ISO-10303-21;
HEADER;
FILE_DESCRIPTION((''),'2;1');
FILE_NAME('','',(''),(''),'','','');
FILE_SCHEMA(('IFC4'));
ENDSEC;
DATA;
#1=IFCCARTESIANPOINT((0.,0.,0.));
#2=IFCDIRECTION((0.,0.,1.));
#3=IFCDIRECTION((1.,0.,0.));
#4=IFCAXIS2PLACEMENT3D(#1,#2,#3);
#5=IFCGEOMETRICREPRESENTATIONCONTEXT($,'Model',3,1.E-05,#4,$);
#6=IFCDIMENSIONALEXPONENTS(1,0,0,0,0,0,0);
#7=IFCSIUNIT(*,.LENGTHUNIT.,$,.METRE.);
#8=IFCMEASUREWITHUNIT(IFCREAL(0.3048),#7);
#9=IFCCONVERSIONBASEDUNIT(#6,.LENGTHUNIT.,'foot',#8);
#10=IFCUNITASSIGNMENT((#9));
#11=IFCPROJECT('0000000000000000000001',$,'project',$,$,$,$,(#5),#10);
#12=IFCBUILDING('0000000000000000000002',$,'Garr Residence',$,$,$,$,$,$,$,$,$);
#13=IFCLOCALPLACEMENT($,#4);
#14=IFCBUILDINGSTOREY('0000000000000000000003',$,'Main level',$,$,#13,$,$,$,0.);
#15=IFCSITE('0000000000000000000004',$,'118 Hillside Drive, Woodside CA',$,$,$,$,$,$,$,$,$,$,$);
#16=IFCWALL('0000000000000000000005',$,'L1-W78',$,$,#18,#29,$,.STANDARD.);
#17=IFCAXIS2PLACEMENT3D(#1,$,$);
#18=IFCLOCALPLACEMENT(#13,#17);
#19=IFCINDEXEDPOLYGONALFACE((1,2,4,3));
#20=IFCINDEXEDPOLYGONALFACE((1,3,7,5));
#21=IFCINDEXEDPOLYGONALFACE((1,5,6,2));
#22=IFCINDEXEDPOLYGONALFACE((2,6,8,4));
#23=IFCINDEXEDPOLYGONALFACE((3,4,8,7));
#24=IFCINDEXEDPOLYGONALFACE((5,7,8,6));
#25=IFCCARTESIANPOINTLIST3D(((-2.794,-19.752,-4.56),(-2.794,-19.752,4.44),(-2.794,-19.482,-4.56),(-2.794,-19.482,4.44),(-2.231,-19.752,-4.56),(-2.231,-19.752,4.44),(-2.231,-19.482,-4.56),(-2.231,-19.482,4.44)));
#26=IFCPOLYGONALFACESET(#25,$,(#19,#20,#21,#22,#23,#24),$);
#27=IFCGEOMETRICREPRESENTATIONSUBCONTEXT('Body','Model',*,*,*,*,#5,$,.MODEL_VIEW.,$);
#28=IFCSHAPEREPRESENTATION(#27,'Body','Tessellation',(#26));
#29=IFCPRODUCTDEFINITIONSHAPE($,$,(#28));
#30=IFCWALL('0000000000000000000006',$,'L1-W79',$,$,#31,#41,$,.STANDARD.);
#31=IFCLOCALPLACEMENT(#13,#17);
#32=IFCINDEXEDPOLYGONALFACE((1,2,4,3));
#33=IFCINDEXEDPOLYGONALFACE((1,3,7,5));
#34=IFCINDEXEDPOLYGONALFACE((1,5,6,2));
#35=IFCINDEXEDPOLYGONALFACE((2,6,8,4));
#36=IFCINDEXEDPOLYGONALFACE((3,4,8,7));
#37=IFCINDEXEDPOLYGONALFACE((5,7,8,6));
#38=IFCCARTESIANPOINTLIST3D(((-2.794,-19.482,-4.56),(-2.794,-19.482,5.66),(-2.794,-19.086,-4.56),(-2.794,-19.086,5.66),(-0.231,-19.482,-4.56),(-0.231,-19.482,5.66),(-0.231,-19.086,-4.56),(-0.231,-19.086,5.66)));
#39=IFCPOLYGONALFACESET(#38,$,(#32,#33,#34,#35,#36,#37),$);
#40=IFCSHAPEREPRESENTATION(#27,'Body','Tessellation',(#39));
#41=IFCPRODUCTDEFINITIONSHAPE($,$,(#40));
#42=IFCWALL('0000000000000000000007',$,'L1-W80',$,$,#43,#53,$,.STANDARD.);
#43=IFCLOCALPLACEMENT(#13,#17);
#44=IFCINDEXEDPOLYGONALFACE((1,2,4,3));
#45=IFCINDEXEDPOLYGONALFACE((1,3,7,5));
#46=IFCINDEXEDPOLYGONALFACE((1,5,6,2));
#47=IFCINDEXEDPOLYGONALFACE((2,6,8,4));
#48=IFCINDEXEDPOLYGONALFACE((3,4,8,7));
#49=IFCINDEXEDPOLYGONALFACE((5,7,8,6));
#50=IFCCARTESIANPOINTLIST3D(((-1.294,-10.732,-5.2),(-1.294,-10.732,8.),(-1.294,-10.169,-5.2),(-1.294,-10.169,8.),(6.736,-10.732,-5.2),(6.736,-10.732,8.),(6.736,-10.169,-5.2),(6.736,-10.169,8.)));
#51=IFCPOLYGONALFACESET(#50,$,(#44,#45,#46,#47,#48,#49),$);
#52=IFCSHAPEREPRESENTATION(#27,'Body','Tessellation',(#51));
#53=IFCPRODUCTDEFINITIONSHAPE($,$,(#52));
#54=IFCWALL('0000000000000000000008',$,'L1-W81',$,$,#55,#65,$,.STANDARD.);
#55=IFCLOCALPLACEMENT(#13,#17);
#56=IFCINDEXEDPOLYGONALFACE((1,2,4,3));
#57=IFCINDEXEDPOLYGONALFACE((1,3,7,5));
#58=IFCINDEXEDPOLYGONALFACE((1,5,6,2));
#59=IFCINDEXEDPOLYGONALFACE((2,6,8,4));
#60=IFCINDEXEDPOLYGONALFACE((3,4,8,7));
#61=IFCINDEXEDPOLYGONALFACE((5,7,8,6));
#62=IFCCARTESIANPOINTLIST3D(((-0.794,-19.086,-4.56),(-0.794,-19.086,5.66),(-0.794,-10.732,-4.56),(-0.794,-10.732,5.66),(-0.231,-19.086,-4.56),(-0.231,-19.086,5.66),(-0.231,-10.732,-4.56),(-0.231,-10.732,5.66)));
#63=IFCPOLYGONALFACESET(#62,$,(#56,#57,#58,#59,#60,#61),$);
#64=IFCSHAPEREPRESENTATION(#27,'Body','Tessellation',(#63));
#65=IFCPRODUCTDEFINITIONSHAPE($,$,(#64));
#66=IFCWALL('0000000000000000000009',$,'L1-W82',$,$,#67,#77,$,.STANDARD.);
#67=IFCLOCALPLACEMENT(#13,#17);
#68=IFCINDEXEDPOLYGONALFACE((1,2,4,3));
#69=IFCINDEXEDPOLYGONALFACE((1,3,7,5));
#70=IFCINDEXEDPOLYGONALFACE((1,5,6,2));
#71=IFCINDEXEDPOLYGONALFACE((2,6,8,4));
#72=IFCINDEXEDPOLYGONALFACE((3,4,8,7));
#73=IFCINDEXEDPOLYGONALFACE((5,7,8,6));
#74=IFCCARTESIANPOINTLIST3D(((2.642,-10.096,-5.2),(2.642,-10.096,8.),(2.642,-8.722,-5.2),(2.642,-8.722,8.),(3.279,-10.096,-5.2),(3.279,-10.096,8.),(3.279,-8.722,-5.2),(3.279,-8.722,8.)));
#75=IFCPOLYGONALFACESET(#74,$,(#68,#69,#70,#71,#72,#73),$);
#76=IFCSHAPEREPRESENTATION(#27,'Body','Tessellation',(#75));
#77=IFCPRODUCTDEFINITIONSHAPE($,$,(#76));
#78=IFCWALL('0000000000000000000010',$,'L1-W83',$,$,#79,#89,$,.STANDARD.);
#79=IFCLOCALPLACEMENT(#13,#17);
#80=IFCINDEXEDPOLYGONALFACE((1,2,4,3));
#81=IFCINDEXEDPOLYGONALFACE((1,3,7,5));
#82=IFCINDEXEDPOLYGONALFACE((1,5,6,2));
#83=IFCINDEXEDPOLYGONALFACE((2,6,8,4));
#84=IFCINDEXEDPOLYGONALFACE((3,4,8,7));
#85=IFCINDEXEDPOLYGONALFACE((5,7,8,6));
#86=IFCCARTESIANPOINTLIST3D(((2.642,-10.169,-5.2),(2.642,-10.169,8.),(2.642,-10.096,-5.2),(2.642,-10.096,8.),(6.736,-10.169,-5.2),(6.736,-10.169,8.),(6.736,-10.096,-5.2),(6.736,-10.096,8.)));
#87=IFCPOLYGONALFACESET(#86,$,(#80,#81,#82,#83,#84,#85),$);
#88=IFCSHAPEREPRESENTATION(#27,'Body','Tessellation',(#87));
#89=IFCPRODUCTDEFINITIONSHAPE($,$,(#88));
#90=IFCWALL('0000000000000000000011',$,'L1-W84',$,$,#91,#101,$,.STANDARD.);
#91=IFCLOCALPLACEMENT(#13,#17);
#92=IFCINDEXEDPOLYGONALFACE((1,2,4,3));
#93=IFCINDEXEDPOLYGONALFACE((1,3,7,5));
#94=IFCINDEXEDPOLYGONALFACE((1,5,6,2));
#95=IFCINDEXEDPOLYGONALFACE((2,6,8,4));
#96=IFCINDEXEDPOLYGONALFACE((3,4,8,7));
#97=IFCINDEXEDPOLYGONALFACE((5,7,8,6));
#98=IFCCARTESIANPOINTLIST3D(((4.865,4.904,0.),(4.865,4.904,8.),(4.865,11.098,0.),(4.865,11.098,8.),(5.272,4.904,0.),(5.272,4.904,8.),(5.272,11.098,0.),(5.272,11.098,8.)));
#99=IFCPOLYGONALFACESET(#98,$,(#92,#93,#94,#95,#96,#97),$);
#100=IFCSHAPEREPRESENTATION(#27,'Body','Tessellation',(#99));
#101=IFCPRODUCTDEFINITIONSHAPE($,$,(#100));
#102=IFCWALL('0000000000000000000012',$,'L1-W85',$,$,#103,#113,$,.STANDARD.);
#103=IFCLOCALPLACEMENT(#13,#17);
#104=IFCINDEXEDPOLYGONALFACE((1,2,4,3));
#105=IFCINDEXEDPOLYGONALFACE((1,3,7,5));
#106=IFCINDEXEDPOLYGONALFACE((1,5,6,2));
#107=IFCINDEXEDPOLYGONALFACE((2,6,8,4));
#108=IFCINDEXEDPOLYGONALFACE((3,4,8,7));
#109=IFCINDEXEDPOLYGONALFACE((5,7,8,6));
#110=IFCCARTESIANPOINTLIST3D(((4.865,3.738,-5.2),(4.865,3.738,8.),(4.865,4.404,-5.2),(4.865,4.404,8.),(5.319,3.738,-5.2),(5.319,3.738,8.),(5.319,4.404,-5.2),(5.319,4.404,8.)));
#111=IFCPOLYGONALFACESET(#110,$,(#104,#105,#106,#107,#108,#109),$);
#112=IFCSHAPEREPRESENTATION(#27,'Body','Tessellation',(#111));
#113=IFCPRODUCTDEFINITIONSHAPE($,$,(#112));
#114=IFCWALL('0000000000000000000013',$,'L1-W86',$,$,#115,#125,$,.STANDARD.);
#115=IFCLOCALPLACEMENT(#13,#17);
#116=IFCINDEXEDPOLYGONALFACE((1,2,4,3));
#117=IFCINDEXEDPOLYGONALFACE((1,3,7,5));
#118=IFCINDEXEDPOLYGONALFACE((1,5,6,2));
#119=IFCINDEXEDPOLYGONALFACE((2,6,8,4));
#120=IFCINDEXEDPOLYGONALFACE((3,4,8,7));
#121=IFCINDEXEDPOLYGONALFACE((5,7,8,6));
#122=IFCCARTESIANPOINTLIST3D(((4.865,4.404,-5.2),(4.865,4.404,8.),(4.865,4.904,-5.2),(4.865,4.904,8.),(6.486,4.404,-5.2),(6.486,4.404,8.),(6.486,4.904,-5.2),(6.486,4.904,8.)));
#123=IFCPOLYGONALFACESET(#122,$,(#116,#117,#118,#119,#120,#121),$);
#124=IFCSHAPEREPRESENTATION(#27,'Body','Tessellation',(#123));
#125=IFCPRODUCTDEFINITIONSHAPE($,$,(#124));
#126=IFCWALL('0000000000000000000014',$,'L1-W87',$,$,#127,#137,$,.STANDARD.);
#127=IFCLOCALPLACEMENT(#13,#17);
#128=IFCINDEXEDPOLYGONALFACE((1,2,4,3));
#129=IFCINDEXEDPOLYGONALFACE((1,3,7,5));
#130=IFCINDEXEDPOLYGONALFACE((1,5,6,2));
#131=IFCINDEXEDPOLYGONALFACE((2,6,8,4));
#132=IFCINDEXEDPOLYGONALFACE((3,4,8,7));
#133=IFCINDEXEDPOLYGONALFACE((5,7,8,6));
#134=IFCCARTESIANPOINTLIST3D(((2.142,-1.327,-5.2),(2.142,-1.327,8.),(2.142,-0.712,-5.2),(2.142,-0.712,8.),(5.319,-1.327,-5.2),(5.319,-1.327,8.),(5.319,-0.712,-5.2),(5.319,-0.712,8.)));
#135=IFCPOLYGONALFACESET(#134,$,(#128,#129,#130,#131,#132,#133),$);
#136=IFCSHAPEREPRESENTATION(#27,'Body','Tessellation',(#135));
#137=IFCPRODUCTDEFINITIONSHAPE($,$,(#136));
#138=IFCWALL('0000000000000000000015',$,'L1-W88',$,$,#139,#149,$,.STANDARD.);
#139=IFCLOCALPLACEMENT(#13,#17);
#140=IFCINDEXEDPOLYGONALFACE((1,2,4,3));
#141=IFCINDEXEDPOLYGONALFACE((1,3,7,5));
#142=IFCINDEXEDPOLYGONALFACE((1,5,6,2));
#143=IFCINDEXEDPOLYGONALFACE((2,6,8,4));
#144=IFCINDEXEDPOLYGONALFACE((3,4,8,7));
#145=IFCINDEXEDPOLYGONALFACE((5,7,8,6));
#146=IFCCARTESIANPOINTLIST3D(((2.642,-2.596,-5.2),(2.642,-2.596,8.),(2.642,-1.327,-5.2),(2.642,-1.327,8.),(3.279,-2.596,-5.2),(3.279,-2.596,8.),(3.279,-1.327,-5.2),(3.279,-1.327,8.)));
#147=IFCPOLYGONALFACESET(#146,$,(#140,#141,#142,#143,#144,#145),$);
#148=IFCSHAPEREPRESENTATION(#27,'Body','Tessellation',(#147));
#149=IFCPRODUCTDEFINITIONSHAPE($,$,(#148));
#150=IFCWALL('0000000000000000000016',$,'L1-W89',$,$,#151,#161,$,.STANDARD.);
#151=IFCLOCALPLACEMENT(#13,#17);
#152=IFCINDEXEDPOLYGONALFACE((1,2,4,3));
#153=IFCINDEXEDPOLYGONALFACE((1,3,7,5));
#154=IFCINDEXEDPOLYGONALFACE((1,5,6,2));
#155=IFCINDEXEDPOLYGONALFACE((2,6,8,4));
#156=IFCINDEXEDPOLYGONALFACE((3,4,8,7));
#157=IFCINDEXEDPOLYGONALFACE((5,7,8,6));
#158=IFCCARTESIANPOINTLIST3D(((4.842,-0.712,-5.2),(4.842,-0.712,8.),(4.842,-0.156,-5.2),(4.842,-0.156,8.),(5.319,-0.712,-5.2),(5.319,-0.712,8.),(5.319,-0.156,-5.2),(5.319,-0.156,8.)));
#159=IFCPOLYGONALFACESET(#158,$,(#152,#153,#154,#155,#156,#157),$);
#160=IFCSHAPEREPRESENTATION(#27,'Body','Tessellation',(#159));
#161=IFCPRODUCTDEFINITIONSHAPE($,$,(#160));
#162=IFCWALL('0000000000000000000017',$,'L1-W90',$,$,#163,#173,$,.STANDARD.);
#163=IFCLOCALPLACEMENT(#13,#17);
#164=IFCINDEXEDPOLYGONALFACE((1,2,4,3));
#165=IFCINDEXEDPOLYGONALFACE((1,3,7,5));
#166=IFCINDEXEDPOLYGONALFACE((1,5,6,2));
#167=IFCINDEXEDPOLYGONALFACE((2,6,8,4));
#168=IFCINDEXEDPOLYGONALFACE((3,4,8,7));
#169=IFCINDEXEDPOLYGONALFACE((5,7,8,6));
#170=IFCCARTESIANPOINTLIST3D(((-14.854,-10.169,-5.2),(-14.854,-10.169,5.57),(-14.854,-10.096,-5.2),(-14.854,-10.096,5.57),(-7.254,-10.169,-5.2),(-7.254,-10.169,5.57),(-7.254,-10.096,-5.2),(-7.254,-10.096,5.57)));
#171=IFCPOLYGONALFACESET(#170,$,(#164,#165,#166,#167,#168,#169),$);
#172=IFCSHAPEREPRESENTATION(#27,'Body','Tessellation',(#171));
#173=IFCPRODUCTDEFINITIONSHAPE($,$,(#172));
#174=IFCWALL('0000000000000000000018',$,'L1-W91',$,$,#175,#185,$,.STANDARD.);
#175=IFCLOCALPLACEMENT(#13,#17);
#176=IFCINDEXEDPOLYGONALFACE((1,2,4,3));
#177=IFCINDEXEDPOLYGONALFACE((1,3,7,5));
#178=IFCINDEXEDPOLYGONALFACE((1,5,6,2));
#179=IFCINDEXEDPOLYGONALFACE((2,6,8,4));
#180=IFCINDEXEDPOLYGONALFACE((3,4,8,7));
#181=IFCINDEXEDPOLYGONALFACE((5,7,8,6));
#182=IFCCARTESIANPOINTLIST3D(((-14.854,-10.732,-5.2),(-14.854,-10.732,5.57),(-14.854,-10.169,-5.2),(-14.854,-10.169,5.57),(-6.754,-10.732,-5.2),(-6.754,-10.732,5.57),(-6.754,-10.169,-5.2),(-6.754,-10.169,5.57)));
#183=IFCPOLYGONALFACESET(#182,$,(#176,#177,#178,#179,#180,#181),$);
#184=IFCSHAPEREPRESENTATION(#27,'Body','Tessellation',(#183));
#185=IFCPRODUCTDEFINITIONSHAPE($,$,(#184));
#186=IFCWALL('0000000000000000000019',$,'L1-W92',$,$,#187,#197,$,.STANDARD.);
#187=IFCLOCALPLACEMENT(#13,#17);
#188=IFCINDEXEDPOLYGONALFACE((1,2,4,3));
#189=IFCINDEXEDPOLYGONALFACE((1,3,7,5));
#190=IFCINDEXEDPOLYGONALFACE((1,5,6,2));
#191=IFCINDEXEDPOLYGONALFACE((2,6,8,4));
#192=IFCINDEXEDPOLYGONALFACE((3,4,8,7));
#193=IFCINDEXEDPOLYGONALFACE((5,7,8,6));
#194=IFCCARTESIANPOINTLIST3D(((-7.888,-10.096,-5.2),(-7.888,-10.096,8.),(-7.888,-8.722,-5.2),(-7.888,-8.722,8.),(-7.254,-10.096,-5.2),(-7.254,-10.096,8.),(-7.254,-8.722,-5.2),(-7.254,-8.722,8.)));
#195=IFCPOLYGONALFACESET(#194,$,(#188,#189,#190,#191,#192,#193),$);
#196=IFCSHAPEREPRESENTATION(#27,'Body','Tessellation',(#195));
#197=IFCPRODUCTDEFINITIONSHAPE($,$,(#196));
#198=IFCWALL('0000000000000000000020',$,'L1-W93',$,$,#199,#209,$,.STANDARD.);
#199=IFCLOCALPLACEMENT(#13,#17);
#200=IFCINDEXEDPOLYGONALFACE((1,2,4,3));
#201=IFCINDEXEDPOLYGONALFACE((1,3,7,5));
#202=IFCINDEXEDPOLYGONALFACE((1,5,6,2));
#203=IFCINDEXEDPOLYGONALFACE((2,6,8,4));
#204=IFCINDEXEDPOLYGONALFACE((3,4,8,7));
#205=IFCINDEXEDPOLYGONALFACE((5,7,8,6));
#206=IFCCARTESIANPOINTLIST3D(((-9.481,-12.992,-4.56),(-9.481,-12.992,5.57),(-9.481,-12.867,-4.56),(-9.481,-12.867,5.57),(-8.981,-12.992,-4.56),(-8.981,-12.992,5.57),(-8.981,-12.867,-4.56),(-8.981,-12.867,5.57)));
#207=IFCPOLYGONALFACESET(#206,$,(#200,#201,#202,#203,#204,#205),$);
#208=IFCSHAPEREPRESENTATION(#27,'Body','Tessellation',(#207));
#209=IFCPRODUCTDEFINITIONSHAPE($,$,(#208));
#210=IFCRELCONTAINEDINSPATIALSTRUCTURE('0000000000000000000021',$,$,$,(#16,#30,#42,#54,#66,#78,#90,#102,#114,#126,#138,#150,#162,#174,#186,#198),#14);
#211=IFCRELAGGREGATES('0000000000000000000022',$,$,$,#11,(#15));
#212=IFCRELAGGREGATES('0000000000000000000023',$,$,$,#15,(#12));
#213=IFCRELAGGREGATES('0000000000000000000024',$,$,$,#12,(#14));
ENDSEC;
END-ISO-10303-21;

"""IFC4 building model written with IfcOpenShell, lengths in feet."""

from ifc_helpers import new_model, entity, si_unit, converted_unit, frame, origin, origin_with_axes, place, context, subcontext, project, spatial, polyline, outline, extrude, element, save


model = new_model("IFC4")

# Units and contexts
model_context = context("Model", 3, precision=1e-05, world=origin_with_axes())
body_context = subcontext(model_context, "Body", "Model", "MODEL_VIEW")
ifc_project = project(units=[converted_unit("LENGTHUNIT", "foot", entity("IfcReal", 0.3048), si_unit("LENGTHUNIT", "METRE"), dimensions=[1, 0, 0, 0, 0, 0, 0])], contexts=[model_context])

# Site, building, storey
site = spatial("IfcSite", under=ifc_project, Name="118 Hillside Drive, Woodside CA")
building = spatial("IfcBuilding", under=site, Name="Garr Residence")
storey_placement = place(None, origin_with_axes())
storey = spatial("IfcBuildingStorey", under=building, at=storey_placement, Name="Main level", Elevation=0.0)

# Walls
wall_1_placement = place(storey_placement, frame((0.0, 0.0, -4.56), z_axis=(0.0, 0.0, 1.0), x_axis=(1.0, 0.0, 0.0)))
element("IfcWall", 1, at=wall_1_placement, inside=storey, Name="L1-W78", PredefinedType="STANDARD", context=body_context, shape_type="SweptSolid", body=[
    extrude(outline(polyline([(-2.231, -19.752), (-2.231, -19.482), (-2.794, -19.482), (-2.794, -19.752), (-2.231, -19.752)])), origin(), (0.0, 0.0, 1.0), 9.0),
])
wall_2_placement = place(storey_placement, frame((0.0, 0.0, -4.56), z_axis=(0.0, 0.0, 1.0), x_axis=(1.0, 0.0, 0.0)))
element("IfcWall", 2, at=wall_2_placement, inside=storey, Name="L1-W79", PredefinedType="STANDARD", context=body_context, shape_type="SweptSolid", body=[
    extrude(outline(polyline([(-0.231, -19.482), (-0.231, -19.086), (-2.794, -19.086), (-2.794, -19.482), (-0.231, -19.482)])), origin(), (0.0, 0.0, 1.0), 10.22),
])
wall_3_placement = place(storey_placement, frame((0.0, 0.0, -5.2), z_axis=(0.0, 0.0, 1.0), x_axis=(1.0, 0.0, 0.0)))
element("IfcWall", 3, at=wall_3_placement, inside=storey, Name="L1-W80", PredefinedType="STANDARD", context=body_context, shape_type="SweptSolid", body=[
    extrude(outline(polyline([(6.736, -10.732), (6.736, -10.169), (-1.294, -10.169), (-1.294, -10.732), (6.736, -10.732)])), origin(), (0.0, 0.0, 1.0), 13.2),
])
wall_4_placement = place(storey_placement, frame((0.0, 0.0, -4.56), z_axis=(0.0, 0.0, 1.0), x_axis=(1.0, 0.0, 0.0)))
element("IfcWall", 4, at=wall_4_placement, inside=storey, Name="L1-W81", PredefinedType="STANDARD", context=body_context, shape_type="SweptSolid", body=[
    extrude(outline(polyline([(-0.231, -19.086), (-0.231, -10.732), (-0.794, -10.732), (-0.794, -19.086), (-0.231, -19.086)])), origin(), (0.0, 0.0, 1.0), 10.22),
])
wall_5_placement = place(storey_placement, frame((0.0, 0.0, -5.2), z_axis=(0.0, 0.0, 1.0), x_axis=(1.0, 0.0, 0.0)))
element("IfcWall", 5, at=wall_5_placement, inside=storey, Name="L1-W82", PredefinedType="STANDARD", context=body_context, shape_type="SweptSolid", body=[
    extrude(outline(polyline([(3.279, -10.096), (3.279, -8.722), (2.642, -8.722), (2.642, -10.096), (3.279, -10.096)])), origin(), (0.0, 0.0, 1.0), 13.2),
])
wall_6_placement = place(storey_placement, frame((0.0, 0.0, -5.2), z_axis=(0.0, 0.0, 1.0), x_axis=(1.0, 0.0, 0.0)))
element("IfcWall", 6, at=wall_6_placement, inside=storey, Name="L1-W83", PredefinedType="STANDARD", context=body_context, shape_type="SweptSolid", body=[
    extrude(outline(polyline([(6.736, -10.169), (6.736, -10.096), (2.642, -10.096), (2.642, -10.169), (6.736, -10.169)])), origin(), (0.0, 0.0, 1.0), 13.2),
])
wall_7_placement = place(storey_placement, origin_with_axes())
element("IfcWall", 7, at=wall_7_placement, inside=storey, Name="L1-W84", PredefinedType="STANDARD", context=body_context, shape_type="SweptSolid", body=[
    extrude(outline(polyline([(5.272, 4.904), (5.272, 11.098), (4.865, 11.098), (4.865, 4.904), (5.272, 4.904)])), origin(), (0.0, 0.0, 1.0), 8.0),
])
wall_8_placement = place(storey_placement, frame((0.0, 0.0, -5.2), z_axis=(0.0, 0.0, 1.0), x_axis=(1.0, 0.0, 0.0)))
element("IfcWall", 8, at=wall_8_placement, inside=storey, Name="L1-W85", PredefinedType="STANDARD", context=body_context, shape_type="SweptSolid", body=[
    extrude(outline(polyline([(5.319, 3.738), (5.319, 4.404), (4.865, 4.404), (4.865, 3.738), (5.319, 3.738)])), origin(), (0.0, 0.0, 1.0), 13.2),
])
wall_9_placement = place(storey_placement, frame((0.0, 0.0, -5.2), z_axis=(0.0, 0.0, 1.0), x_axis=(1.0, 0.0, 0.0)))
element("IfcWall", 9, at=wall_9_placement, inside=storey, Name="L1-W86", PredefinedType="STANDARD", context=body_context, shape_type="SweptSolid", body=[
    extrude(outline(polyline([(6.486, 4.404), (6.486, 4.904), (4.865, 4.904), (4.865, 4.404), (6.486, 4.404)])), origin(), (0.0, 0.0, 1.0), 13.2),
])
wall_10_placement = place(storey_placement, frame((0.0, 0.0, -5.2), z_axis=(0.0, 0.0, 1.0), x_axis=(1.0, 0.0, 0.0)))
element("IfcWall", 10, at=wall_10_placement, inside=storey, Name="L1-W87", PredefinedType="STANDARD", context=body_context, shape_type="SweptSolid", body=[
    extrude(outline(polyline([(5.319, -1.327), (5.319, -0.712), (2.142, -0.712), (2.142, -1.327), (5.319, -1.327)])), origin(), (0.0, 0.0, 1.0), 13.2),
])
wall_11_placement = place(storey_placement, frame((0.0, 0.0, -5.2), z_axis=(0.0, 0.0, 1.0), x_axis=(1.0, 0.0, 0.0)))
element("IfcWall", 11, at=wall_11_placement, inside=storey, Name="L1-W88", PredefinedType="STANDARD", context=body_context, shape_type="SweptSolid", body=[
    extrude(outline(polyline([(3.279, -2.596), (3.279, -1.327), (2.642, -1.327), (2.642, -2.596), (3.279, -2.596)])), origin(), (0.0, 0.0, 1.0), 13.2),
])
wall_12_placement = place(storey_placement, frame((0.0, 0.0, -5.2), z_axis=(0.0, 0.0, 1.0), x_axis=(1.0, 0.0, 0.0)))
element("IfcWall", 12, at=wall_12_placement, inside=storey, Name="L1-W89", PredefinedType="STANDARD", context=body_context, shape_type="SweptSolid", body=[
    extrude(outline(polyline([(5.319, -0.712), (5.319, -0.156), (4.842, -0.156), (4.842, -0.712), (5.319, -0.712)])), origin(), (0.0, 0.0, 1.0), 13.2),
])
wall_13_placement = place(storey_placement, frame((0.0, 0.0, -5.2), z_axis=(0.0, 0.0, 1.0), x_axis=(1.0, 0.0, 0.0)))
element("IfcWall", 13, at=wall_13_placement, inside=storey, Name="L1-W90", PredefinedType="STANDARD", context=body_context, shape_type="SweptSolid", body=[
    extrude(outline(polyline([(-7.254, -10.169), (-7.254, -10.096), (-14.854, -10.096), (-14.854, -10.169), (-7.254, -10.169)])), origin(), (0.0, 0.0, 1.0), 10.77),
])
wall_14_placement = place(storey_placement, frame((0.0, 0.0, -5.2), z_axis=(0.0, 0.0, 1.0), x_axis=(1.0, 0.0, 0.0)))
element("IfcWall", 14, at=wall_14_placement, inside=storey, Name="L1-W91", PredefinedType="STANDARD", context=body_context, shape_type="SweptSolid", body=[
    extrude(outline(polyline([(-6.754, -10.732), (-6.754, -10.169), (-14.854, -10.169), (-14.854, -10.732), (-6.754, -10.732)])), origin(), (0.0, 0.0, 1.0), 10.77),
])
wall_15_placement = place(storey_placement, frame((0.0, 0.0, -5.2), z_axis=(0.0, 0.0, 1.0), x_axis=(1.0, 0.0, 0.0)))
element("IfcWall", 15, at=wall_15_placement, inside=storey, Name="L1-W92", PredefinedType="STANDARD", context=body_context, shape_type="SweptSolid", body=[
    extrude(outline(polyline([(-7.254, -10.096), (-7.254, -8.722), (-7.888, -8.722), (-7.888, -10.096), (-7.254, -10.096)])), origin(), (0.0, 0.0, 1.0), 13.2),
])
wall_16_placement = place(storey_placement, frame((0.0, 0.0, -4.56), z_axis=(0.0, 0.0, 1.0), x_axis=(1.0, 0.0, 0.0)))
element("IfcWall", 16, at=wall_16_placement, inside=storey, Name="L1-W93", PredefinedType="STANDARD", context=body_context, shape_type="SweptSolid", body=[
    extrude(outline(polyline([(-8.981, -12.992), (-8.981, -12.867), (-9.481, -12.867), (-9.481, -12.992), (-8.981, -12.992)])), origin(), (0.0, 0.0, 1.0), 10.13),
])

save(model, "model.ifc")
